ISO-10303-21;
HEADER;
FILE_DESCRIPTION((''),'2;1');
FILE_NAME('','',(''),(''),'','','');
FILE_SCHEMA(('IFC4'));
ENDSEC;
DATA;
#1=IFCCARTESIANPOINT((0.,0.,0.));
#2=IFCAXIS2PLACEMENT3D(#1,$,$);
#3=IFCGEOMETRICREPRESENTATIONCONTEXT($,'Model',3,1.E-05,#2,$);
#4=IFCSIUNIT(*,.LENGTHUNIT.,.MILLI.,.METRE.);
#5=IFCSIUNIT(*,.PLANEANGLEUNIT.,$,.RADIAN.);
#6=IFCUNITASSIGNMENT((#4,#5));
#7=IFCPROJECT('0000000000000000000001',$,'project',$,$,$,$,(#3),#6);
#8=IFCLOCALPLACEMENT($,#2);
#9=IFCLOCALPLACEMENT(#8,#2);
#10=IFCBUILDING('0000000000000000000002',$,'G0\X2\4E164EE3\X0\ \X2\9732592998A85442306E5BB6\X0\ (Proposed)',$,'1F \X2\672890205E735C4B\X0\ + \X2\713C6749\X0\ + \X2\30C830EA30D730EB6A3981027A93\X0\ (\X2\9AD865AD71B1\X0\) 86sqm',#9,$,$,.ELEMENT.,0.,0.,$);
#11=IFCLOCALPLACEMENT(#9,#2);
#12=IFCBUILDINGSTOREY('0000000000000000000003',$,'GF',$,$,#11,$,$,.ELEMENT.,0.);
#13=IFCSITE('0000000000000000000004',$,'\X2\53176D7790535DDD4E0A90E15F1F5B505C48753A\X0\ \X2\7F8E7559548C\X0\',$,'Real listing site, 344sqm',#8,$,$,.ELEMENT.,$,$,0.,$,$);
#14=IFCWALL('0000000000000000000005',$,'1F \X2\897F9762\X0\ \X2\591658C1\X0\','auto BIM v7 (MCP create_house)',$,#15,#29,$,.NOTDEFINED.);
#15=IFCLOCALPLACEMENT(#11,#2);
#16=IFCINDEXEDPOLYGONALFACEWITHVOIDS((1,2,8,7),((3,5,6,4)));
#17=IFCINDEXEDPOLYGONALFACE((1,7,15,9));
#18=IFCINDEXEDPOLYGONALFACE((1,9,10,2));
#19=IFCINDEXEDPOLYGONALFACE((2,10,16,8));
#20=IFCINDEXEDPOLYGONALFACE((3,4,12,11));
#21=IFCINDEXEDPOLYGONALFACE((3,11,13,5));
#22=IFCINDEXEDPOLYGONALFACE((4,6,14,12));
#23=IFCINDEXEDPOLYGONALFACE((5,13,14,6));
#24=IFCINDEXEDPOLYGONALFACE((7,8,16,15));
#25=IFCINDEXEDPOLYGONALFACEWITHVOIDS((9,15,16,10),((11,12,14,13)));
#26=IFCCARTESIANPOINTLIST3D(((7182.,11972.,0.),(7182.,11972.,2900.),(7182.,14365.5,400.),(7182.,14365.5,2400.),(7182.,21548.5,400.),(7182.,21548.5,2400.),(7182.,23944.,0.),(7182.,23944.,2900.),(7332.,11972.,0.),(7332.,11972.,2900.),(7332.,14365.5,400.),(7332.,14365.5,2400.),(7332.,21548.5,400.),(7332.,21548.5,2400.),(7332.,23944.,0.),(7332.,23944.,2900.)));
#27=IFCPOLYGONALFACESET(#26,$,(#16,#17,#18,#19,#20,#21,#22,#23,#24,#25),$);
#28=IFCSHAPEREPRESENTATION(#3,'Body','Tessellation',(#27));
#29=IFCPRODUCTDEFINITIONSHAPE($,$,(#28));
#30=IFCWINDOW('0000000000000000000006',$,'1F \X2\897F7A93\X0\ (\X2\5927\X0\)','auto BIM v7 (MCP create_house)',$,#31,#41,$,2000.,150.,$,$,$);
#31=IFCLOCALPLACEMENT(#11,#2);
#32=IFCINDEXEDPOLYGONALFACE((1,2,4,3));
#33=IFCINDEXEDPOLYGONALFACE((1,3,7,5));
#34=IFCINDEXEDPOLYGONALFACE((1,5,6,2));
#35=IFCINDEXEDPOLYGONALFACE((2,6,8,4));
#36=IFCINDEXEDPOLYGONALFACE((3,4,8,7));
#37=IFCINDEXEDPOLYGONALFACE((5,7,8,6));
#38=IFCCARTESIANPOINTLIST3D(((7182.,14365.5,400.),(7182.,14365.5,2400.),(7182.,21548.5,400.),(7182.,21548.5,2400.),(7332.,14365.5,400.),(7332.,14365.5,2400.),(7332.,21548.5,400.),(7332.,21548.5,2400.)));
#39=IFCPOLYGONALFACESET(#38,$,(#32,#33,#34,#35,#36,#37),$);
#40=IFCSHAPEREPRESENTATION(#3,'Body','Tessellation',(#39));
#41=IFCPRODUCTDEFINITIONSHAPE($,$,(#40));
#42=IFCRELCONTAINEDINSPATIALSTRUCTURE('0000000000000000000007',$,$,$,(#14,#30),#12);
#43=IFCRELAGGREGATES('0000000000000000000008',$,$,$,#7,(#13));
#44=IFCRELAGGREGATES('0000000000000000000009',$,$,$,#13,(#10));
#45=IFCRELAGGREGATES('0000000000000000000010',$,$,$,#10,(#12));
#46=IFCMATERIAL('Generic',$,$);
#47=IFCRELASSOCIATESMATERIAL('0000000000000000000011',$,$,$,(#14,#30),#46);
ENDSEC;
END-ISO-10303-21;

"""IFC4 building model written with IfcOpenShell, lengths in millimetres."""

from ifc_helpers import new_model, si_unit, frame, frame_2d, origin, place, context, project, spatial, rectangle, extrude, material, element, fill, save


model = new_model("IFC4")

# Units and contexts
model_context = context("Model", 3, precision=1e-05, world=origin())
ifc_project = project(units=[si_unit("LENGTHUNIT", "METRE", prefix="MILLI"), si_unit("PLANEANGLEUNIT", "RADIAN")], contexts=[model_context])

# Site, building, storey
site_placement = place(None, origin())
site = spatial("IfcSite", under=ifc_project, at=site_placement, Name="北海道川上郡弟子屈町 美留和", ObjectType="Real listing site, 344sqm", CompositionType="ELEMENT", RefElevation=0.0)
building_placement = place(site_placement, origin())
building = spatial("IfcBuilding", under=site, at=building_placement, Name="G0世代 露天風呂の家 (Proposed)", ObjectType="1F 木造平屋 + 焼杉 + トリプル樹脂窓 (高断熱) 86sqm", CompositionType="ELEMENT", ElevationOfRefHeight=0.0, ElevationOfTerrain=0.0)
storey_placement = place(building_placement, origin())
storey = spatial("IfcBuildingStorey", under=building, at=storey_placement, Name="GF", CompositionType="ELEMENT", Elevation=0.0)

# Shared definitions
ifc_material = material(Name="Generic")

# Wall, opening, window
wall_1_placement = place(storey_placement, frame((3591.0, 5986.0, 0.0)))
wall_1 = element("IfcWall", 1, at=wall_1_placement, inside=storey, material=ifc_material, Name="1F 西面 外壁", Description="auto BIM v7 (MCP create_house)", PredefinedType="NOTDEFINED", context=model_context, shape_type="SweptSolid", body=[
    extrude(rectangle(XDim=150.0, YDim=11972.0, at=frame_2d((75.0, 5986.0))), frame((3591.0, 5986.0, 0.0)), (0.0, 0.0, 1.0), 2900.0),
])
opening_1_placement = place(storey_placement, frame((3591.0, 7183.0, 200.0)))
opening_1 = element("IfcOpeningElement", 2, at=opening_1_placement, cuts=wall_1, PredefinedType="NOTDEFINED", context=model_context, shape_type="SweptSolid", body=[
    extrude(rectangle(XDim=150.0, YDim=7183.0, at=frame_2d((75.0, 3591.0))), frame((3591.0, 7183.0, 200.0)), (0.0, 0.0, 1.0), 2000.0),
])
window_1_placement = place(storey_placement, frame((3591.0, 7183.0, 200.0)))
window_1 = element("IfcWindow", 3, at=window_1_placement, inside=storey, material=ifc_material, Name="1F 西窓 (大)", Description="auto BIM v7 (MCP create_house)", OverallHeight=2000.0, OverallWidth=150.0, context=model_context, shape_type="SweptSolid", body=[
    extrude(rectangle(XDim=150.0, YDim=7183.0, at=frame_2d((75.0, 3591.0))), frame((3591.0, 7183.0, 200.0)), (0.0, 0.0, 1.0), 2000.0),
])
fill(opening_1, window_1)

save(model, "model.ifc")
